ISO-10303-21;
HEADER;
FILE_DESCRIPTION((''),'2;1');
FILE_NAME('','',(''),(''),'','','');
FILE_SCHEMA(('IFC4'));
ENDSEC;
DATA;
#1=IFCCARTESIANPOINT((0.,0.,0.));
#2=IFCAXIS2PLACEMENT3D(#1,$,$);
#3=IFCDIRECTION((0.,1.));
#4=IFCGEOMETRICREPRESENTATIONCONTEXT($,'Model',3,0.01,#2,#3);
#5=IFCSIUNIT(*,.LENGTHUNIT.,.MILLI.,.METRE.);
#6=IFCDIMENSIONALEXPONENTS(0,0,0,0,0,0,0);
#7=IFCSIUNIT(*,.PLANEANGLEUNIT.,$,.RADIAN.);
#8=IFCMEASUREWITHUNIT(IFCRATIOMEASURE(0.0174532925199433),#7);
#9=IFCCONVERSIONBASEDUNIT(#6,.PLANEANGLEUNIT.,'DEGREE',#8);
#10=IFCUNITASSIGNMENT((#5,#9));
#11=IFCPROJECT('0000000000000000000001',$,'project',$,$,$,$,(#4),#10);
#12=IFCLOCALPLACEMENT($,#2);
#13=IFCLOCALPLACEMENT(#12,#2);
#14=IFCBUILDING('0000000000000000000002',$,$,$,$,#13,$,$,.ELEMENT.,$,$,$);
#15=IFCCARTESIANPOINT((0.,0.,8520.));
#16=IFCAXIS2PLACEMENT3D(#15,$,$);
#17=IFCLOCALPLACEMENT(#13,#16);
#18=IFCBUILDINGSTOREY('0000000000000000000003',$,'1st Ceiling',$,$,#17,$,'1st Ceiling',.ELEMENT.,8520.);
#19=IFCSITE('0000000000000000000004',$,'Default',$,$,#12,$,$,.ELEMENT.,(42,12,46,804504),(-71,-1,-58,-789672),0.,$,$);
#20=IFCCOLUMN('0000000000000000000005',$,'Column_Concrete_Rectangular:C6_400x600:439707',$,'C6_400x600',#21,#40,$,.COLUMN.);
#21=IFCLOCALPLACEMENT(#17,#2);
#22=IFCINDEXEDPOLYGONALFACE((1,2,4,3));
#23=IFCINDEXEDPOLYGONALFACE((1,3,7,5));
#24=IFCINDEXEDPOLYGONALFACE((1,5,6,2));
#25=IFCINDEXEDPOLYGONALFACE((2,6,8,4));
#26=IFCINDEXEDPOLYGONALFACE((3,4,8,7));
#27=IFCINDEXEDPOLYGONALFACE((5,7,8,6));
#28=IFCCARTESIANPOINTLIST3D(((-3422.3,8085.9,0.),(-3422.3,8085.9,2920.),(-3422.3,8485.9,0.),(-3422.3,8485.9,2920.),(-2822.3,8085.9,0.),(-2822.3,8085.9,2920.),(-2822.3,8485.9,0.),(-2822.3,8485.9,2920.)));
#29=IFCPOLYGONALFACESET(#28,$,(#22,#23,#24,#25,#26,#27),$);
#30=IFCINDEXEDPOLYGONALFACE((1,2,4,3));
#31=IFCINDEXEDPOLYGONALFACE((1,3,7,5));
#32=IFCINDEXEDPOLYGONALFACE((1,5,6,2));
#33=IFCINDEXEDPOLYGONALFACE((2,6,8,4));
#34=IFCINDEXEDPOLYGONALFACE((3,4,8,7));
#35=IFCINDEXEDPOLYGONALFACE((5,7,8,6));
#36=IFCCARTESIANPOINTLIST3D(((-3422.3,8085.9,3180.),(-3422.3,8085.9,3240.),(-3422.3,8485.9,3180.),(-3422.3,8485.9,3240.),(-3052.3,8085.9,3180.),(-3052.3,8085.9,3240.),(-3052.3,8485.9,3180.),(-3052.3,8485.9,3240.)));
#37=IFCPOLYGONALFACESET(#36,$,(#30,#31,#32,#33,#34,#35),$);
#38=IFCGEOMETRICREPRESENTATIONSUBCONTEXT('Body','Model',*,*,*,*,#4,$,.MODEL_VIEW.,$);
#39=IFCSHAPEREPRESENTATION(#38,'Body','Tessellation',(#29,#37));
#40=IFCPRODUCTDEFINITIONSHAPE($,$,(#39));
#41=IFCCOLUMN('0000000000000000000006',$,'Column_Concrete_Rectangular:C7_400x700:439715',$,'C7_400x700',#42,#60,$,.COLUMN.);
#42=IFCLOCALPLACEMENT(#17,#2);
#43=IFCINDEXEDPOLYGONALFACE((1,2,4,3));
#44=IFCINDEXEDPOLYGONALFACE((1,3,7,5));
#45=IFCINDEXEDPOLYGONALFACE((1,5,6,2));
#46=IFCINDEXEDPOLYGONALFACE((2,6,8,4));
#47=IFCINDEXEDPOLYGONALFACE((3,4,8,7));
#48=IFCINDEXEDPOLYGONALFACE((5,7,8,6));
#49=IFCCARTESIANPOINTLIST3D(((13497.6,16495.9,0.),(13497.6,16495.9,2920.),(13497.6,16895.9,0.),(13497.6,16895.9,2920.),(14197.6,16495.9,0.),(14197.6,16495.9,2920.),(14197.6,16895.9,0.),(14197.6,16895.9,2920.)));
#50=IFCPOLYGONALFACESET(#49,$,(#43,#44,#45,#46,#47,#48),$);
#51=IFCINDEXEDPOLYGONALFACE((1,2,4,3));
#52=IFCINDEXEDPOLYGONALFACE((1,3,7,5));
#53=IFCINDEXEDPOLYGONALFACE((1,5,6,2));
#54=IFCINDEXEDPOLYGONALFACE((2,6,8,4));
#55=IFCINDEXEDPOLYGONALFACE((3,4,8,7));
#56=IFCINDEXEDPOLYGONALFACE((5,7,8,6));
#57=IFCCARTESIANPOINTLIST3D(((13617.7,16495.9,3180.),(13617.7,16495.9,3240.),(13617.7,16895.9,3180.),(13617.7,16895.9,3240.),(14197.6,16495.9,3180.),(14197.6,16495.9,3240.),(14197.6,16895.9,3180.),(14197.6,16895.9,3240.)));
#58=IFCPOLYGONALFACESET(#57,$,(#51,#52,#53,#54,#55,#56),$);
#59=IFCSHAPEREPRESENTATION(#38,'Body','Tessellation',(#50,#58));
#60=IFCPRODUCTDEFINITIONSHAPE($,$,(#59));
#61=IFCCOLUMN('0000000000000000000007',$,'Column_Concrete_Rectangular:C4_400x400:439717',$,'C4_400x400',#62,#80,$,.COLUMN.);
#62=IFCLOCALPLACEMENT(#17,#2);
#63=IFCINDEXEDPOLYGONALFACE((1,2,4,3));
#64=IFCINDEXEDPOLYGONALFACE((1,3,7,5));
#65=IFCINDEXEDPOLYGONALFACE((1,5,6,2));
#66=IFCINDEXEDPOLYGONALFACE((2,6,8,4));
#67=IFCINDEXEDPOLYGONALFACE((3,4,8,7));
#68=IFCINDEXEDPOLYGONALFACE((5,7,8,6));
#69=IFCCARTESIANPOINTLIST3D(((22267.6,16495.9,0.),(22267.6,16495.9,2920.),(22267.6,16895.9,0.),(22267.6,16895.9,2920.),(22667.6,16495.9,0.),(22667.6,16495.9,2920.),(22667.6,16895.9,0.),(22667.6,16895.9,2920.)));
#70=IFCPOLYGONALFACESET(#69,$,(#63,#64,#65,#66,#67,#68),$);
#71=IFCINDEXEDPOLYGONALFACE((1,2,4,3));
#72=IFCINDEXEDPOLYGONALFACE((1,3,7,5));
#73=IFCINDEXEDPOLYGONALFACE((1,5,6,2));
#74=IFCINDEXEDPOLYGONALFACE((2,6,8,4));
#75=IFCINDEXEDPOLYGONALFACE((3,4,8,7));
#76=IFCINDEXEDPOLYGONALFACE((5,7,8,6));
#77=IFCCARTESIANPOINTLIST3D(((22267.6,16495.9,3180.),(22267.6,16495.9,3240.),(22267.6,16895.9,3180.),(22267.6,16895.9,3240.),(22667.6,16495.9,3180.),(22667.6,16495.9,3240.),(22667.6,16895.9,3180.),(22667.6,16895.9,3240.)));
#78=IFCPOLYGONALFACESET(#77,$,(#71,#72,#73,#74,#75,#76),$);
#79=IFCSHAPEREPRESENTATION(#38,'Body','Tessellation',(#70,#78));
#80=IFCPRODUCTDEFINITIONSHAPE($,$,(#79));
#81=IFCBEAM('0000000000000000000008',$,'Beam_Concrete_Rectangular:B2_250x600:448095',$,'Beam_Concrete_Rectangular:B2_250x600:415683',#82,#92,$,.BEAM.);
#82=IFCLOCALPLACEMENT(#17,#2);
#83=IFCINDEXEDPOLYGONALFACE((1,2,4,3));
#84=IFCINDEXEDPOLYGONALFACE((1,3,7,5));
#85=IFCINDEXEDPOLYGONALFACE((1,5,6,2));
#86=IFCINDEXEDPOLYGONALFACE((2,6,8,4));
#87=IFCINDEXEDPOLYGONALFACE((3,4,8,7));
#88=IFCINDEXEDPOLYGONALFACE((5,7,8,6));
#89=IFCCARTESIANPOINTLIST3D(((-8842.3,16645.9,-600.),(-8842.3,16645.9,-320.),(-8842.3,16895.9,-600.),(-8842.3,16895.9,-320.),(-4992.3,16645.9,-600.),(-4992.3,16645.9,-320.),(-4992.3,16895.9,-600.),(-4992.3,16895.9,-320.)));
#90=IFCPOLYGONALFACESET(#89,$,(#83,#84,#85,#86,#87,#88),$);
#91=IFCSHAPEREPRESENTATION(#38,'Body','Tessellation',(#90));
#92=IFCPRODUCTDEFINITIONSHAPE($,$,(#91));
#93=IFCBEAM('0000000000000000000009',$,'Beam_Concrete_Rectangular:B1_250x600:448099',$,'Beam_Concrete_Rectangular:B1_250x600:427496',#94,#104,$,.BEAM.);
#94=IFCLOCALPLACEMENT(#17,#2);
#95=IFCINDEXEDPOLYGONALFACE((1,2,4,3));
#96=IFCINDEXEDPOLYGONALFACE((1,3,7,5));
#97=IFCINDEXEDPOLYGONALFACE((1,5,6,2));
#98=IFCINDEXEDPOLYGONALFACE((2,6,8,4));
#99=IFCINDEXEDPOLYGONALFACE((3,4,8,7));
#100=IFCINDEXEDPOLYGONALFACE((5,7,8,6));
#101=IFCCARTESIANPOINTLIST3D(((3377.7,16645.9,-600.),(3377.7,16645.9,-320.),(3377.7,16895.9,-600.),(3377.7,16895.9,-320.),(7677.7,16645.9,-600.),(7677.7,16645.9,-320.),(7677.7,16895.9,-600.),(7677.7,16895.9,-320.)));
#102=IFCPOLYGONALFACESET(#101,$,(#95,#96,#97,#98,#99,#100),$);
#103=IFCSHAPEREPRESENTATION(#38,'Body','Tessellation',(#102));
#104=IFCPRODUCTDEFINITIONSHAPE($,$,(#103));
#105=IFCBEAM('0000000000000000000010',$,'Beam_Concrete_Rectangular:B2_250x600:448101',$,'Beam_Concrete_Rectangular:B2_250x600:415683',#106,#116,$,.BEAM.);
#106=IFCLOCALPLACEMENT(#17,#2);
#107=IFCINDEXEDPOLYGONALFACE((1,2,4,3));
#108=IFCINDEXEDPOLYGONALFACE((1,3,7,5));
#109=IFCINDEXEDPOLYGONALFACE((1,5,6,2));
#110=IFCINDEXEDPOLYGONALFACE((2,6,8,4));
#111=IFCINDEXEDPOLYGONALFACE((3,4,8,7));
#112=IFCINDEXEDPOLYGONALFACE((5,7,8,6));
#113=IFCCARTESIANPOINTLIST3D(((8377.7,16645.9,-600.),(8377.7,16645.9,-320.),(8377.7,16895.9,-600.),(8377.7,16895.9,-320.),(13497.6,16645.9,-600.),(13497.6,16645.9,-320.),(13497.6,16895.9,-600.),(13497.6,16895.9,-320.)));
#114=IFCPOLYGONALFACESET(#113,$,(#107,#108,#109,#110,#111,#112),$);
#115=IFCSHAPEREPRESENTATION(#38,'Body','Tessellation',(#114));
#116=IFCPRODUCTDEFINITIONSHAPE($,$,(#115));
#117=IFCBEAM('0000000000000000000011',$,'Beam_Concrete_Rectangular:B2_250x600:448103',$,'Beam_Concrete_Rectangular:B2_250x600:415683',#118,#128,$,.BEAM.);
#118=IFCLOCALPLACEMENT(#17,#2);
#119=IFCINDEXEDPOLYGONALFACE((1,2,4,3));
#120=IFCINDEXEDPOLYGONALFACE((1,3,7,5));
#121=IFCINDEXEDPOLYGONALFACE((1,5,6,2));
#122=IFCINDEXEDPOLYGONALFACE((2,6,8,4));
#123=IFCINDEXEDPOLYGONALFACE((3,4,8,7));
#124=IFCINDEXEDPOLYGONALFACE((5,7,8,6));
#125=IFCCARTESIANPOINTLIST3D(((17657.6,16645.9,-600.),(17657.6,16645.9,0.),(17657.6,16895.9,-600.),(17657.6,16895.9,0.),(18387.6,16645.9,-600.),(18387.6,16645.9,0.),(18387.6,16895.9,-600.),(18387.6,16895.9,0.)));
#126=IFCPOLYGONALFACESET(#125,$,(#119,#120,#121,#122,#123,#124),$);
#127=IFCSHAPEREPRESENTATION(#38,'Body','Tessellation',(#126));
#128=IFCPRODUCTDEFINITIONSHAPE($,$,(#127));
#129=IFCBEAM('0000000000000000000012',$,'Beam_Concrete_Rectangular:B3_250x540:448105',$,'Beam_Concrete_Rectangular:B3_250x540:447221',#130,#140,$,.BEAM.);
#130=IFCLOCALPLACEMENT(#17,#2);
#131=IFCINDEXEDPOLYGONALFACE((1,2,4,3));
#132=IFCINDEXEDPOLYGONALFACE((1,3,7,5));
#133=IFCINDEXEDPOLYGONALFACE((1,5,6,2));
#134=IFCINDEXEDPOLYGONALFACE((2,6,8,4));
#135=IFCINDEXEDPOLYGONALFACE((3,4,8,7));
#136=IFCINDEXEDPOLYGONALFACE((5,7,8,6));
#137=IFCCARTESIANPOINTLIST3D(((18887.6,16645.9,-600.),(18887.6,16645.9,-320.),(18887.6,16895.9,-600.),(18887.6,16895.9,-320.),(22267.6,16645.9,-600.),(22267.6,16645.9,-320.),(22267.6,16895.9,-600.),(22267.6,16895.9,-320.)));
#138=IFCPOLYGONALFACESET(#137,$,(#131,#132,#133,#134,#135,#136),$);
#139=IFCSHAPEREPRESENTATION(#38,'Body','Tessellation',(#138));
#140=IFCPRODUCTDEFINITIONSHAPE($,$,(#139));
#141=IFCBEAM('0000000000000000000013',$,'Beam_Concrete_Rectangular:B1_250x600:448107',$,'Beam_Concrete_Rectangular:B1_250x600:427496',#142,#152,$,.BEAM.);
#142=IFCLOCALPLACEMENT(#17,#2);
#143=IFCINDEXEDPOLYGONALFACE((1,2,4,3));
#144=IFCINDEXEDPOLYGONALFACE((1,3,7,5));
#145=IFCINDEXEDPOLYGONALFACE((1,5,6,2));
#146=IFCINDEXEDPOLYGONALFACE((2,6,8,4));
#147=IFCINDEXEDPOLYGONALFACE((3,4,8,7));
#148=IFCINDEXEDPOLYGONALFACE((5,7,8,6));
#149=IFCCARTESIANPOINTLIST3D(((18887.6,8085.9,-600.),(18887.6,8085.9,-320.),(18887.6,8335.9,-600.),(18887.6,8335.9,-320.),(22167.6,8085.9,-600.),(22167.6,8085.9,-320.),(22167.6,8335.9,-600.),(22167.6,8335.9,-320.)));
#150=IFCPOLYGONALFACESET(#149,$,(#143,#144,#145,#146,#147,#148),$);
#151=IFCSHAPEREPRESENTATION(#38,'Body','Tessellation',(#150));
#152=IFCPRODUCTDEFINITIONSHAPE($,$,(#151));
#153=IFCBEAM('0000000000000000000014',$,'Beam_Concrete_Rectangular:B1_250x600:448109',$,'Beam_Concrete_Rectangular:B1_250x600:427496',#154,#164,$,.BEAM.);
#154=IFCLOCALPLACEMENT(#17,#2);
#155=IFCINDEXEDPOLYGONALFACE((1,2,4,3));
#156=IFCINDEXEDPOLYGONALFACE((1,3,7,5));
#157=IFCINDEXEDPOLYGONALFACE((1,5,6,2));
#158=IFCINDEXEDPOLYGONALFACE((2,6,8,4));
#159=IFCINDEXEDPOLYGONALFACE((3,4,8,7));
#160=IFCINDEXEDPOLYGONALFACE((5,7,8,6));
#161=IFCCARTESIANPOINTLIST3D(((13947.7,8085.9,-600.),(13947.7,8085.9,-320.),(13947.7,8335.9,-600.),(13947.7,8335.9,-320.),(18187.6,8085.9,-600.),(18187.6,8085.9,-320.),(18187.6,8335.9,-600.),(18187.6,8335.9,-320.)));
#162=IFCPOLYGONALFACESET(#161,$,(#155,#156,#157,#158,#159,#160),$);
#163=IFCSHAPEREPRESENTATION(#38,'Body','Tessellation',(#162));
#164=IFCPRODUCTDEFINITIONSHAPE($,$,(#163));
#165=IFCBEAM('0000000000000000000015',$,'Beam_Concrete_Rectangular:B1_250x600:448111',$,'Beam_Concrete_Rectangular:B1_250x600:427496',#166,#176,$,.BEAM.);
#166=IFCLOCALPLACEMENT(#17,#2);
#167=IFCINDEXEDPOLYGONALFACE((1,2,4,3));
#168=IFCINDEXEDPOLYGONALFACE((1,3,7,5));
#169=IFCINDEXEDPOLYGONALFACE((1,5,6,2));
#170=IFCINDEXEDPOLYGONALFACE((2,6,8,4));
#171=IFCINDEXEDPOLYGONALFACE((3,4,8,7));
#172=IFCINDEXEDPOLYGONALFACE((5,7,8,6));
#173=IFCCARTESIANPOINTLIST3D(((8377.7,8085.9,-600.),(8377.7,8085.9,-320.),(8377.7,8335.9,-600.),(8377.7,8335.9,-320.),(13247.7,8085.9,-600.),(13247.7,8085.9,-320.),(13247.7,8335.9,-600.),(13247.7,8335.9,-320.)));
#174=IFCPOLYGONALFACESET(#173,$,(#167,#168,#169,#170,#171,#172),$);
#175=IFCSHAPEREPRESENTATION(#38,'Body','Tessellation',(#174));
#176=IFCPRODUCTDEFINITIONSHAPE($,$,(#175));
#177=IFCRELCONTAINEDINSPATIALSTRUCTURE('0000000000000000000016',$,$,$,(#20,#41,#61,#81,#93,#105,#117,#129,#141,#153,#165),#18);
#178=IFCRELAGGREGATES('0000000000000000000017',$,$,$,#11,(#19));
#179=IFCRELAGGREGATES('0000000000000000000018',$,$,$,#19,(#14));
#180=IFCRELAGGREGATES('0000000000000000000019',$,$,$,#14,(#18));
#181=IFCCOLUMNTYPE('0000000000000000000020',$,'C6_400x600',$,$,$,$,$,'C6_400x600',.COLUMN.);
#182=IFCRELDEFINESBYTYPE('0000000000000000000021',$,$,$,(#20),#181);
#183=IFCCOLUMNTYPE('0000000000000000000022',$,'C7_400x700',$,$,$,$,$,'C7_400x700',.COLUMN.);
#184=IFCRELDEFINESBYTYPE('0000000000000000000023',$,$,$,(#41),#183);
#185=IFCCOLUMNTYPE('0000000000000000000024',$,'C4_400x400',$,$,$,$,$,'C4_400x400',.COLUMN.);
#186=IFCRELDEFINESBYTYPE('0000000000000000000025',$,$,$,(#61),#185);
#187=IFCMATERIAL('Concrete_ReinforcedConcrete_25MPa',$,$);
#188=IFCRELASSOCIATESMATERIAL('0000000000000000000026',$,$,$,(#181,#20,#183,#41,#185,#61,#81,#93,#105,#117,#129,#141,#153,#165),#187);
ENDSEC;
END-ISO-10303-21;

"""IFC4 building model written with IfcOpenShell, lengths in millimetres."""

from ifc_helpers import new_model, entity, si_unit, converted_unit, direction, frame, frame_2d, origin, origin_2d_with_axis, place, context, subcontext, project, spatial, rectangle, extrude, source, transform, mapped, material, type_object, type_shapes, element, save


model = new_model("IFC4")

# Units and contexts
model_context = context("Model", 3, precision=0.01, world=origin(), true_north=direction((0.0, 1.0)))
body_context = subcontext(model_context, "Body", "Model", "MODEL_VIEW")
ifc_project = project(units=[si_unit("LENGTHUNIT", "METRE", prefix="MILLI"), converted_unit("PLANEANGLEUNIT", "DEGREE", entity("IfcRatioMeasure", 0.0174532925199433), si_unit("PLANEANGLEUNIT", "RADIAN"), dimensions=[0, 0, 0, 0, 0, 0, 0])], contexts=[model_context])

# Site, building, storey
site_placement = place(None, origin())
site = spatial("IfcSite", under=ifc_project, at=site_placement, Name="Default", CompositionType="ELEMENT", RefLatitude=(42, 12, 46, 804504), RefLongitude=(-71, -1, -58, -789672), RefElevation=0.0)
building_placement = place(site_placement, origin())
building = spatial("IfcBuilding", under=site, at=building_placement, CompositionType="ELEMENT")
storey_placement = place(building_placement, frame((0.0, 0.0, 8520.0)))
storey = spatial("IfcBuildingStorey", under=building, at=storey_placement, Name="1st Ceiling", LongName="1st Ceiling", CompositionType="ELEMENT", Elevation=8520.0)

# Columns
ifc_material = material(Name="Concrete_ReinforcedConcrete_25MPa")
column_type_1 = type_object("IfcColumnType", Name="C6_400x600", ElementType="C6_400x600", PredefinedType="COLUMN", material=ifc_material)
shared_shape_1 = source(origin(), body_context, "Body", "SweptSolid", [
    extrude(rectangle(XDim=400.0, YDim=600.0, at=origin_2d_with_axis()), frame((-3122.3, 8285.9, 8520.0), z_axis=(0.0, 0.0, 1.0), x_axis=(0.0, -1.0, 0.0)), (0.0, 0.0, 1.0), 2920.0),
    extrude(rectangle(XDim=400.0, YDim=370.0, at=frame_2d((0.0, 0.0), x_axis=(1.0, 0.0))), frame((-3237.3, 8285.9, 11700.0), z_axis=(0.0, 0.0, 1.0), x_axis=(0.0, -1.0, 0.0)), (0.0, 0.0, 1.0), 60.0),
])
type_shapes(column_type_1, [shared_shape_1])
column_1_placement = place(storey_placement, frame((0.0, 0.0, -8520.0)))
element("IfcColumn", 1, at=column_1_placement, inside=storey, type_object=column_type_1, material=ifc_material, Name="Column_Concrete_Rectangular:C6_400x600:439707", ObjectType="C6_400x600", PredefinedType="COLUMN", context=body_context, shape_type="MappedRepresentation", body=[
    mapped(shared_shape_1, transform((0.0, 0.0, 0.0), scale=1.0)),
])
column_type_2 = type_object("IfcColumnType", Name="C7_400x700", ElementType="C7_400x700", PredefinedType="COLUMN", material=ifc_material)
shared_shape_2 = source(origin(), body_context, "Body", "SweptSolid", [
    extrude(rectangle(XDim=400.0, YDim=700.0, at=frame_2d((0.0, 0.0), x_axis=(1.0, 0.0))), frame((13847.6, 16695.9, 8520.0), z_axis=(0.0, 0.0, 1.0), x_axis=(0.0, -1.0, 0.0)), (0.0, 0.0, 1.0), 2920.0),
    extrude(rectangle(XDim=400.0, YDim=580.0, at=frame_2d((0.0, 0.0), x_axis=(1.0, 0.0))), frame((13907.6, 16695.9, 11700.0), z_axis=(0.0, 0.0, 1.0), x_axis=(0.0, -1.0, 0.0)), (0.0, 0.0, 1.0), 60.0),
])
type_shapes(column_type_2, [shared_shape_2])
column_2_placement = place(storey_placement, frame((0.0, 0.0, -8520.0)))
element("IfcColumn", 2, at=column_2_placement, inside=storey, type_object=column_type_2, material=ifc_material, Name="Column_Concrete_Rectangular:C7_400x700:439715", ObjectType="C7_400x700", PredefinedType="COLUMN", context=body_context, shape_type="MappedRepresentation", body=[
    mapped(shared_shape_2, transform((0.0, 0.0, 0.0), scale=1.0)),
])
column_type_3 = type_object("IfcColumnType", Name="C4_400x400", ElementType="C4_400x400", PredefinedType="COLUMN", material=ifc_material)
shared_shape_3 = source(origin(), body_context, "Body", "SweptSolid", [
    extrude(rectangle(XDim=400.0, YDim=400.0, at=frame_2d((0.0, 0.0), x_axis=(1.0, 0.0))), frame((22467.6, 16695.9, 8520.0), z_axis=(0.0, 0.0, 1.0), x_axis=(0.0, -1.0, 0.0)), (0.0, 0.0, 1.0), 2920.0),
    extrude(rectangle(XDim=400.0, YDim=400.0, at=frame_2d((0.0, 0.0), x_axis=(1.0, 0.0))), frame((22467.6, 16695.9, 11700.0), z_axis=(0.0, 0.0, 1.0), x_axis=(0.0, -1.0, 0.0)), (0.0, 0.0, 1.0), 60.0),
])
type_shapes(column_type_3, [shared_shape_3])
column_3_placement = place(storey_placement, frame((0.0, 0.0, -8520.0)))
element("IfcColumn", 3, at=column_3_placement, inside=storey, type_object=column_type_3, material=ifc_material, Name="Column_Concrete_Rectangular:C4_400x400:439717", ObjectType="C4_400x400", PredefinedType="COLUMN", context=body_context, shape_type="MappedRepresentation", body=[
    mapped(shared_shape_3, transform((0.0, 0.0, 0.0), scale=1.0)),
])

# Beams
beam_1_placement = place(storey_placement, frame((-9042.3, 16645.9, 0.0)))
element("IfcBeam", 4, at=beam_1_placement, inside=storey, material=ifc_material, Name="Beam_Concrete_Rectangular:B2_250x600:448095", ObjectType="Beam_Concrete_Rectangular:B2_250x600:415683", PredefinedType="BEAM", context=body_context, shape_type="SweptSolid", body=[
    extrude(rectangle(XDim=280.0, YDim=250.0, at=origin_2d_with_axis()), frame((200.0, 125.0, -460.0), z_axis=(1.0, 0.0, 0.0), x_axis=(0.0, 0.0, -1.0)), (0.0, 0.0, 1.0), 3850.0),
])
beam_2_placement = place(storey_placement, frame((8027.7, 16895.9, 0.0), z_axis=(0.0, 0.0, 1.0), x_axis=(-1.0, 0.0, 0.0)))
element("IfcBeam", 5, at=beam_2_placement, inside=storey, material=ifc_material, Name="Beam_Concrete_Rectangular:B1_250x600:448099", ObjectType="Beam_Concrete_Rectangular:B1_250x600:427496", PredefinedType="BEAM", context=body_context, shape_type="SweptSolid", body=[
    extrude(rectangle(XDim=280.0, YDim=250.0, at=origin_2d_with_axis()), frame((350.0, 125.0, -460.0), z_axis=(1.0, 0.0, 0.0), x_axis=(0.0, 0.0, -1.0)), (0.0, 0.0, 1.0), 4300.0),
])
beam_3_placement = place(storey_placement, frame((13847.6, 16895.9, 0.0), z_axis=(0.0, 0.0, 1.0), x_axis=(-1.0, 0.0, 0.0)))
element("IfcBeam", 6, at=beam_3_placement, inside=storey, material=ifc_material, Name="Beam_Concrete_Rectangular:B2_250x600:448101", ObjectType="Beam_Concrete_Rectangular:B2_250x600:415683", PredefinedType="BEAM", context=body_context, shape_type="SweptSolid", body=[
    extrude(rectangle(XDim=280.0, YDim=250.0, at=origin_2d_with_axis()), frame((350.0, 125.0, -460.0), z_axis=(1.0, 0.0, 0.0), x_axis=(0.0, 0.0, -1.0)), (0.0, 0.0, 1.0), 5120.0),
])
beam_4_placement = place(storey_placement, frame((18637.6, 16895.9, 0.0), z_axis=(0.0, 0.0, 1.0), x_axis=(-1.0, 0.0, 0.0)))
element("IfcBeam", 7, at=beam_4_placement, inside=storey, material=ifc_material, Name="Beam_Concrete_Rectangular:B2_250x600:448103", ObjectType="Beam_Concrete_Rectangular:B2_250x600:415683", PredefinedType="BEAM", context=body_context, shape_type="SweptSolid", body=[
    extrude(rectangle(XDim=600.0, YDim=250.0, at=origin_2d_with_axis()), frame((250.0, 125.0, -300.0), z_axis=(1.0, 0.0, 0.0), x_axis=(0.0, 0.0, -1.0)), (0.0, 0.0, 1.0), 730.0),
])
beam_5_placement = place(storey_placement, frame((22467.6, 16895.9, 0.0), z_axis=(0.0, 0.0, 1.0), x_axis=(-1.0, 0.0, 0.0)))
element("IfcBeam", 8, at=beam_5_placement, inside=storey, material=ifc_material, Name="Beam_Concrete_Rectangular:B3_250x540:448105", ObjectType="Beam_Concrete_Rectangular:B3_250x540:447221", PredefinedType="BEAM", context=body_context, shape_type="SweptSolid", body=[
    extrude(rectangle(XDim=280.0, YDim=250.0, at=origin_2d_with_axis()), frame((200.0, 125.0, -460.0), z_axis=(1.0, 0.0, 0.0), x_axis=(0.0, 0.0, -1.0)), (0.0, 0.0, 1.0), 3380.0),
])
beam_6_placement = place(storey_placement, frame((18537.6, 8085.9, 0.0)))
element("IfcBeam", 9, at=beam_6_placement, inside=storey, material=ifc_material, Name="Beam_Concrete_Rectangular:B1_250x600:448107", ObjectType="Beam_Concrete_Rectangular:B1_250x600:427496", PredefinedType="BEAM", context=body_context, shape_type="SweptSolid", body=[
    extrude(rectangle(XDim=280.0, YDim=250.0, at=frame_2d((0.0, 0.0), x_axis=(1.0, 0.0))), frame((350.0, 125.0, -460.0), z_axis=(1.0, 0.0, 0.0), x_axis=(0.0, 0.0, -1.0)), (0.0, 0.0, 1.0), 3280.0),
])
beam_7_placement = place(storey_placement, frame((13597.7, 8085.9, 0.0)))
element("IfcBeam", 10, at=beam_7_placement, inside=storey, material=ifc_material, Name="Beam_Concrete_Rectangular:B1_250x600:448109", ObjectType="Beam_Concrete_Rectangular:B1_250x600:427496", PredefinedType="BEAM", context=body_context, shape_type="SweptSolid", body=[
    extrude(rectangle(XDim=280.0, YDim=250.0, at=frame_2d((0.0, 0.0), x_axis=(1.0, 0.0))), frame((350.0, 125.0, -460.0), z_axis=(1.0, 0.0, 0.0), x_axis=(0.0, 0.0, -1.0)), (0.0, 0.0, 1.0), 4240.0),
])
beam_8_placement = place(storey_placement, frame((8027.7, 8085.9, 0.0)))
element("IfcBeam", 11, at=beam_8_placement, inside=storey, material=ifc_material, Name="Beam_Concrete_Rectangular:B1_250x600:448111", ObjectType="Beam_Concrete_Rectangular:B1_250x600:427496", PredefinedType="BEAM", context=body_context, shape_type="SweptSolid", body=[
    extrude(rectangle(XDim=280.0, YDim=250.0, at=frame_2d((0.0, 0.0), x_axis=(1.0, 0.0))), frame((350.0, 125.0, -460.0), z_axis=(1.0, 0.0, 0.0), x_axis=(0.0, 0.0, -1.0)), (0.0, 0.0, 1.0), 4870.0),
])

save(model, "model.ifc")
